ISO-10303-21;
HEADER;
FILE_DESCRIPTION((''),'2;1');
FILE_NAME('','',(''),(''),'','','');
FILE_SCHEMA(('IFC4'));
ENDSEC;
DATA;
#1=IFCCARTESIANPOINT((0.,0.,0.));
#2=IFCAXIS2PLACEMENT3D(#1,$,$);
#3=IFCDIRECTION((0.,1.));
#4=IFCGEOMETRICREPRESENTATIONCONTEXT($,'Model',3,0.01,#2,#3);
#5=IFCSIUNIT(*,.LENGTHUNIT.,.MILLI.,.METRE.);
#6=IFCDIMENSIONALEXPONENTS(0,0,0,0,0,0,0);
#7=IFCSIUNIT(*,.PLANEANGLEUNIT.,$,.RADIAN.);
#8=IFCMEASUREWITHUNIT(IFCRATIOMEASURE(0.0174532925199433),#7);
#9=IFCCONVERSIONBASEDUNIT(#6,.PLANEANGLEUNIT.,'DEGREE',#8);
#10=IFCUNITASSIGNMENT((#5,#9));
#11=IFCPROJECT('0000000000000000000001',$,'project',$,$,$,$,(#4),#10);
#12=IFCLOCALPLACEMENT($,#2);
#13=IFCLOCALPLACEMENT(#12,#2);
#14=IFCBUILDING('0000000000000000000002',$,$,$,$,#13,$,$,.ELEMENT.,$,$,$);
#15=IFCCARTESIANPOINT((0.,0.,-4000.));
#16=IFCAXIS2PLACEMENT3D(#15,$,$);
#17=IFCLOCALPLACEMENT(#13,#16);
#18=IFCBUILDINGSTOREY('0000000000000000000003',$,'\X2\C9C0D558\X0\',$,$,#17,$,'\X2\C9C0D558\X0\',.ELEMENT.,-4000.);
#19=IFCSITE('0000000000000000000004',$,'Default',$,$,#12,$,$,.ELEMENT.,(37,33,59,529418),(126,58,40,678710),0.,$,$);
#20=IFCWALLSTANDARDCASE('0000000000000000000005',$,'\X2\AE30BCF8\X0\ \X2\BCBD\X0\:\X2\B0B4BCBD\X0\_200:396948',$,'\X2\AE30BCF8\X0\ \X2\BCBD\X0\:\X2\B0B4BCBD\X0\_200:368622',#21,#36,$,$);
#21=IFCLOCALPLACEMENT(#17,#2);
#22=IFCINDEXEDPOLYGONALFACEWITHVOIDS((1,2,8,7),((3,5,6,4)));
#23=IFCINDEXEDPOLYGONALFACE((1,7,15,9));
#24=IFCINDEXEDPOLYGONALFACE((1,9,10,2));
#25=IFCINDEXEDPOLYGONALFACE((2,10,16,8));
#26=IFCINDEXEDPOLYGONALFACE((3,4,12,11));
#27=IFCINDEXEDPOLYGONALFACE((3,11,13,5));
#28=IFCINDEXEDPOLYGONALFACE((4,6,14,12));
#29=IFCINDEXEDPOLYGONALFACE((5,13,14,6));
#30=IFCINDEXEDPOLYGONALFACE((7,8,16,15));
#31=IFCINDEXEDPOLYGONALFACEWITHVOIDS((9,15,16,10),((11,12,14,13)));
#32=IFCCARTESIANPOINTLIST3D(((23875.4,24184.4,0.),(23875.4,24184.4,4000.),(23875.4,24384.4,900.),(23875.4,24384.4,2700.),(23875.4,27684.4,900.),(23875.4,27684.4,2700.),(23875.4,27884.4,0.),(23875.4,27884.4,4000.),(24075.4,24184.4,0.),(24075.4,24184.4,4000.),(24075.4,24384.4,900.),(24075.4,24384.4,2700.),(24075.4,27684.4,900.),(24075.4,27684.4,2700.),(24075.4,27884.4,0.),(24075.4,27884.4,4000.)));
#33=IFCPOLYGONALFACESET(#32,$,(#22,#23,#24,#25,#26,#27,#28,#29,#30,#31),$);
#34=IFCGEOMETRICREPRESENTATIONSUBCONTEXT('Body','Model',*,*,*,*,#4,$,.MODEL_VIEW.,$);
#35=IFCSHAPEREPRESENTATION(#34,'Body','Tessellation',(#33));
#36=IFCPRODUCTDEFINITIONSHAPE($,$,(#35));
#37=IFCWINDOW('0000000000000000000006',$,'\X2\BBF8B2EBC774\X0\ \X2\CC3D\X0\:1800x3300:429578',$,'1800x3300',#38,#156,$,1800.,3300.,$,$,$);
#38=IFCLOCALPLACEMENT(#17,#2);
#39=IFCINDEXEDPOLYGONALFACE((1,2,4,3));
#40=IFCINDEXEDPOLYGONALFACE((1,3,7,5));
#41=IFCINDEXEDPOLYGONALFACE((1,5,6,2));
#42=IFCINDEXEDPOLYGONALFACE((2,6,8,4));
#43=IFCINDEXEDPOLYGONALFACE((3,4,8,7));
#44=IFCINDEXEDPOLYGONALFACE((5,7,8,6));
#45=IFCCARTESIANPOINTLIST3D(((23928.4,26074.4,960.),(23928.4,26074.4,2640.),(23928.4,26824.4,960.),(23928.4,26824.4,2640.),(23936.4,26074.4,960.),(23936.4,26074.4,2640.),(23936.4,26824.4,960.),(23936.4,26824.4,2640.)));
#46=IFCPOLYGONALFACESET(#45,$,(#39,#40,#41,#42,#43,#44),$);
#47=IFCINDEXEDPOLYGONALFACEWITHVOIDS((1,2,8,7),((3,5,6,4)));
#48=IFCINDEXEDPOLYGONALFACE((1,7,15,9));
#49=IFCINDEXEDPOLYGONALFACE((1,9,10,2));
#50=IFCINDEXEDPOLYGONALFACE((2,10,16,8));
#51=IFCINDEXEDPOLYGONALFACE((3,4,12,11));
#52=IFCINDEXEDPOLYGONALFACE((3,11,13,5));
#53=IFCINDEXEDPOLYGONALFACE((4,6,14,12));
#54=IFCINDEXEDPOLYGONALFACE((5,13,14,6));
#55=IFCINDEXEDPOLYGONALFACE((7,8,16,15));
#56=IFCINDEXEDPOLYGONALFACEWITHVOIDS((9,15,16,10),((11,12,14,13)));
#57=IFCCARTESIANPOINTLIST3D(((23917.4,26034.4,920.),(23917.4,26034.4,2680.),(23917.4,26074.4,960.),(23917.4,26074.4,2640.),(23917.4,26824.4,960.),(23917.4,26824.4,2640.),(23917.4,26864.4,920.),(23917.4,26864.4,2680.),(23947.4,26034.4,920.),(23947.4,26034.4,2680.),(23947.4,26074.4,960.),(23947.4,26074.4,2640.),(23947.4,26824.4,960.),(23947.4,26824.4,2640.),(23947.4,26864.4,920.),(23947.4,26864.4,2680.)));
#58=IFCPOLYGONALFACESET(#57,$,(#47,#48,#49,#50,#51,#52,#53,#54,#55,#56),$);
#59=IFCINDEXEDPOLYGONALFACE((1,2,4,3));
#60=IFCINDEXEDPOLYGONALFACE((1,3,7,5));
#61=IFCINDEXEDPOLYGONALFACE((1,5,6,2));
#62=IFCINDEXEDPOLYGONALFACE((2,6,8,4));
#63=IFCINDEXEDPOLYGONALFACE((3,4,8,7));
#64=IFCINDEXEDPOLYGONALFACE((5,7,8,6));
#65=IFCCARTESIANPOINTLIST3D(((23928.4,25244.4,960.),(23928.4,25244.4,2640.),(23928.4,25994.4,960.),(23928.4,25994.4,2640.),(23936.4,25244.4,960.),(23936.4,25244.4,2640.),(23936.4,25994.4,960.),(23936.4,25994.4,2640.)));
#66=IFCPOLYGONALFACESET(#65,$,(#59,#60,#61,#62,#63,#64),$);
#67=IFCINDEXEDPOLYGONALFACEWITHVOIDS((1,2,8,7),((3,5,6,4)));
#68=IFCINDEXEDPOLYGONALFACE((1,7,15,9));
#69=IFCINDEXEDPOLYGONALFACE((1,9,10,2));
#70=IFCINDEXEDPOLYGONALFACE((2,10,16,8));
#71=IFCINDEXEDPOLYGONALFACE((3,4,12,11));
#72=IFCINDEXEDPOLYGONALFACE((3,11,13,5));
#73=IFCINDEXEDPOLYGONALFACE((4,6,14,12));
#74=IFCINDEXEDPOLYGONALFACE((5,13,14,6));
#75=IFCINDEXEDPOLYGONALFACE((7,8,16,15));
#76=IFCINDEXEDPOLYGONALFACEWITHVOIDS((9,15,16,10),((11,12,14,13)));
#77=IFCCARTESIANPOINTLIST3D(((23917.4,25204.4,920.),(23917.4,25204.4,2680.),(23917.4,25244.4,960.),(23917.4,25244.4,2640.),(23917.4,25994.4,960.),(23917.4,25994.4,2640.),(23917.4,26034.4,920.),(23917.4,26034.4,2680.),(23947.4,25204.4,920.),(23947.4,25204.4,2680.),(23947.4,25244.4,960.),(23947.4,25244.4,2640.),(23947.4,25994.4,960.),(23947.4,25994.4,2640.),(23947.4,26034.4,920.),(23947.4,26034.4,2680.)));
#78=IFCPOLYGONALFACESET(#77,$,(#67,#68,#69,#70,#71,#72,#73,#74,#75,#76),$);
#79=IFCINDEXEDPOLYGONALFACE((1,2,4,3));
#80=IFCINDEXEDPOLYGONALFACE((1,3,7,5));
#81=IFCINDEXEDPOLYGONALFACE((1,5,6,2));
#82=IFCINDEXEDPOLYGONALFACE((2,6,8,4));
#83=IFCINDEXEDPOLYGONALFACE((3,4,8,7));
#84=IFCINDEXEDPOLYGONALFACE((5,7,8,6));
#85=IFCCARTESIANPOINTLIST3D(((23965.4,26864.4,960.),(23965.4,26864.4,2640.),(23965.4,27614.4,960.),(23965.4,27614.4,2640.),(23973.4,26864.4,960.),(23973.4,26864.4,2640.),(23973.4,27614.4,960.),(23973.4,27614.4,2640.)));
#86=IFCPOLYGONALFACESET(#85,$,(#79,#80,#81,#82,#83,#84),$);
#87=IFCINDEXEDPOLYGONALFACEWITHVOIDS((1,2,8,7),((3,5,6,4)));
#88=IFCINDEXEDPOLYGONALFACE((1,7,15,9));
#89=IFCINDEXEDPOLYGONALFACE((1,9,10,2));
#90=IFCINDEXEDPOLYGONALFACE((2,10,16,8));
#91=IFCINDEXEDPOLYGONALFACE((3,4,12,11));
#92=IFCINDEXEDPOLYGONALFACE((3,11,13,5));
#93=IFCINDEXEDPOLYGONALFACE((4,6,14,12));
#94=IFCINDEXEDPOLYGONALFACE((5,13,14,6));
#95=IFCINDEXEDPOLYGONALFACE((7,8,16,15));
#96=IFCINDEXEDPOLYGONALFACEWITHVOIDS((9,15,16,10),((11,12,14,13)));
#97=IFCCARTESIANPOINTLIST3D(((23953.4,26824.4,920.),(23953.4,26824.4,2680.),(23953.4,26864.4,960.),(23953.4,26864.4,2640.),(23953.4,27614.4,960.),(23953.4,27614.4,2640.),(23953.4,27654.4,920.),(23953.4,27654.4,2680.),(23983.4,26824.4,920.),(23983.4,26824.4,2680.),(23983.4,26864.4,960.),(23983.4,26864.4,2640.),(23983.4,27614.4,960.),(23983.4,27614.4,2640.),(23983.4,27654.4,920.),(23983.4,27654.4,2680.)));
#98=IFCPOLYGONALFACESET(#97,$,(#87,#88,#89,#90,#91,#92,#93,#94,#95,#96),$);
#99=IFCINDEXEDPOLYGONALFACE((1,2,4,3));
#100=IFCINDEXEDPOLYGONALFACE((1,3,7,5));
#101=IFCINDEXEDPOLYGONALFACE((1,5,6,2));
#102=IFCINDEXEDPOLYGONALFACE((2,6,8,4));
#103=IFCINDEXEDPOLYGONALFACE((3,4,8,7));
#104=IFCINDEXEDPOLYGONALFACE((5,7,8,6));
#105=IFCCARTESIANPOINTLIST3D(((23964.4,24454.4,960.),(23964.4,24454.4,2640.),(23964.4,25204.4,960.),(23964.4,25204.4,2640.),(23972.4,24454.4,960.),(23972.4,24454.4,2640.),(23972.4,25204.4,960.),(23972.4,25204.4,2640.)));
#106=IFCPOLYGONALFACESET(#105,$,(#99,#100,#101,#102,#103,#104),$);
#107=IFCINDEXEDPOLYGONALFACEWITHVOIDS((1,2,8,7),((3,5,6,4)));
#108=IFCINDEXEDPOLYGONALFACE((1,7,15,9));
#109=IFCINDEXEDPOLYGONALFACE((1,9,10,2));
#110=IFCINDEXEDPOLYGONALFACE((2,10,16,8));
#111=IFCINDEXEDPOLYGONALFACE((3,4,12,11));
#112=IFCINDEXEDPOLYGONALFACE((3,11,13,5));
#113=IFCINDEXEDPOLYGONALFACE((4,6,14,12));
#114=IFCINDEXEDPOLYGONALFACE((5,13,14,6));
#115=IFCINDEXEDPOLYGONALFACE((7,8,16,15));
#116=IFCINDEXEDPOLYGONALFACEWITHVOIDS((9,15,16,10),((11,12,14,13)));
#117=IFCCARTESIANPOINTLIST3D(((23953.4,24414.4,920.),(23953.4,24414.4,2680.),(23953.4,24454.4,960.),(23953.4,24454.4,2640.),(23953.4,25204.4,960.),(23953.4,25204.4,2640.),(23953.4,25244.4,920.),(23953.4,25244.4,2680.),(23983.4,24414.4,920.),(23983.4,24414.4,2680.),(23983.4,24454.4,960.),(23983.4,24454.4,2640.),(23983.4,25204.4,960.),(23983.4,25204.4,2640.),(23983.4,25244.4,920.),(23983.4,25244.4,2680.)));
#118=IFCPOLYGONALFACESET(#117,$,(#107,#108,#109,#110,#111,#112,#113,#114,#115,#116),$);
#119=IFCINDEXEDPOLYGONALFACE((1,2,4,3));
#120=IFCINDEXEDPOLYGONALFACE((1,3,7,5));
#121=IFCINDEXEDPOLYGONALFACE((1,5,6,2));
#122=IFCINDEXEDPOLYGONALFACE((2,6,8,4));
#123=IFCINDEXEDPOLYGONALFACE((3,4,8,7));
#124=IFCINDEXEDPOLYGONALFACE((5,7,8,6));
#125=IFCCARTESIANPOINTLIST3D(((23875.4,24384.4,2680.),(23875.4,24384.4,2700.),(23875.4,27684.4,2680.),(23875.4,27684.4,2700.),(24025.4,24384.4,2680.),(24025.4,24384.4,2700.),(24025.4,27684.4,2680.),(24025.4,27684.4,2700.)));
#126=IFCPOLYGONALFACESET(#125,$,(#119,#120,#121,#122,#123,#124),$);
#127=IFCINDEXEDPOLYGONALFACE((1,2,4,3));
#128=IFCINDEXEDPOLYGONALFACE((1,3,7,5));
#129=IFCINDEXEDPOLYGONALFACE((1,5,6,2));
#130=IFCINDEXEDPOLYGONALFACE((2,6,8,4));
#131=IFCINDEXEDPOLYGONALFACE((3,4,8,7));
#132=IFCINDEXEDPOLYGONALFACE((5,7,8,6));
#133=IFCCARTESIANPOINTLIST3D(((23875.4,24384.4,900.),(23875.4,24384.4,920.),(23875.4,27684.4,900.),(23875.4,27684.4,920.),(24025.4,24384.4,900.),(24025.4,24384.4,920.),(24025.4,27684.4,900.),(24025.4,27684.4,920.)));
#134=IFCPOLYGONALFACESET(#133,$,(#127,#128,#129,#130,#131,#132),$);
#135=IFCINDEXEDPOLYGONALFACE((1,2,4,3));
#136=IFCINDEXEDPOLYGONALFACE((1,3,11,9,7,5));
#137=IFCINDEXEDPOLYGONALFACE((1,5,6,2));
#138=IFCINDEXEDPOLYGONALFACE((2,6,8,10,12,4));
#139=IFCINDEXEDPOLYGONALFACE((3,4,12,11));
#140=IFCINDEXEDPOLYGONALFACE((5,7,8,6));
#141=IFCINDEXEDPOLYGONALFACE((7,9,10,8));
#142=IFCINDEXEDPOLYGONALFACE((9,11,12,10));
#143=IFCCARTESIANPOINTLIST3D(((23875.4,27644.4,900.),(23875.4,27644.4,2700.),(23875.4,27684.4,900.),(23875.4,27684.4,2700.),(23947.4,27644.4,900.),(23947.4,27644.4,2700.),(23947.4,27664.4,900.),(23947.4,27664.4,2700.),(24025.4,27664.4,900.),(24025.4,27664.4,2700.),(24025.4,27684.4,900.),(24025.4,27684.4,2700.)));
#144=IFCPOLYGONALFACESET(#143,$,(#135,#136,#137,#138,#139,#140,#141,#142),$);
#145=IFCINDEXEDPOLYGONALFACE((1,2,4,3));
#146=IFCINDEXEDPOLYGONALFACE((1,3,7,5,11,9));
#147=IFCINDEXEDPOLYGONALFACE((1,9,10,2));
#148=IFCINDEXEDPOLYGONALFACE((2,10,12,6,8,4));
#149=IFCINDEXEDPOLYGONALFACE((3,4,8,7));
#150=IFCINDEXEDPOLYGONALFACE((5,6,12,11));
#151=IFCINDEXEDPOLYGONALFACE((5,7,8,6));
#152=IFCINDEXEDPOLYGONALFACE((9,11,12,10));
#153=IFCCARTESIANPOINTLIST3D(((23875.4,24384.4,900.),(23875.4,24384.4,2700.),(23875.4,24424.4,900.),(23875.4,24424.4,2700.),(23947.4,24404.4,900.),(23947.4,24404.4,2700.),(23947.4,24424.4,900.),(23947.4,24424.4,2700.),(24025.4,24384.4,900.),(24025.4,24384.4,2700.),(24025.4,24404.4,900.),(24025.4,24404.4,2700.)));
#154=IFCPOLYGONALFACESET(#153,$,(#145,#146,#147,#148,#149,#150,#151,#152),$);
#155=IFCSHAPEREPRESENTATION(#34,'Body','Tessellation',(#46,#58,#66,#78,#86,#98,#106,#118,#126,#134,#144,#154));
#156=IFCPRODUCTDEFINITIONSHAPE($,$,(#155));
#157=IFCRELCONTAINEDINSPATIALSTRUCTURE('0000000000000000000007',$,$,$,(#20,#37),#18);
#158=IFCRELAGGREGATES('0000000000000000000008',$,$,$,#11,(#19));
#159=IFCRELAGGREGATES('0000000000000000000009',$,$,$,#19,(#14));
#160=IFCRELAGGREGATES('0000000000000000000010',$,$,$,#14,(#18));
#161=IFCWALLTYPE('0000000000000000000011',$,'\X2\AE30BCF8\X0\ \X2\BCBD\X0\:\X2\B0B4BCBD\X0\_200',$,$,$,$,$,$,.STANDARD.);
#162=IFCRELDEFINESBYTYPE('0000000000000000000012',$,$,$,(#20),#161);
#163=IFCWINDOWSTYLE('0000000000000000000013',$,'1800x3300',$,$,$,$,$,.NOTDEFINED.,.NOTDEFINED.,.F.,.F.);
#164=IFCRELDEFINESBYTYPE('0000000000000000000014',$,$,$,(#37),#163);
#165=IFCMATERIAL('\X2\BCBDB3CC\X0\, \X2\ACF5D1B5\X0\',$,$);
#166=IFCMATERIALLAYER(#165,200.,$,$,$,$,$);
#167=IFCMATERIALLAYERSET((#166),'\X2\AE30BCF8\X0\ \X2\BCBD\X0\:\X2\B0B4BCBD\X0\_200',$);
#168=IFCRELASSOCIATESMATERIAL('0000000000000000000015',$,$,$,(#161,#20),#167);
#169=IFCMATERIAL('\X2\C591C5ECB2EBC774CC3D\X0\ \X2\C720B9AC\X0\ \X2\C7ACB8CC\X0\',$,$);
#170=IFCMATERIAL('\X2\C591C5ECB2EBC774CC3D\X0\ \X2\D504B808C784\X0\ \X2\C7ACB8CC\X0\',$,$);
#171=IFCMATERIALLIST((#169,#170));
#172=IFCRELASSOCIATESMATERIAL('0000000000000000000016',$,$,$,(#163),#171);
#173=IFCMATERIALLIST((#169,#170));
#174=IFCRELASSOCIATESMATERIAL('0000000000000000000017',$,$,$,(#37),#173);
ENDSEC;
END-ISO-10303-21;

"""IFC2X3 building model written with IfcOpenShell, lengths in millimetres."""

from ifc_helpers import new_model, entity, si_unit, converted_unit, direction, frame, frame_2d, origin, origin_2d_with_axis, place, context, subcontext, project, spatial, polyline, rectangle, outline, extrude, source, transform, mapped, material, material_list, layer, layer_set, layer_usage, type_object, type_shapes, element, fill, save


model = new_model("IFC2X3")

# Units and contexts
model_context = context("Model", 3, precision=0.01, world=origin(), true_north=direction((0.0, 1.0)))
body_context = subcontext(model_context, "Body", "Model", "MODEL_VIEW")
ifc_project = project(units=[si_unit("LENGTHUNIT", "METRE", prefix="MILLI"), converted_unit("PLANEANGLEUNIT", "DEGREE", entity("IfcRatioMeasure", 0.0174532925199433), si_unit("PLANEANGLEUNIT", "RADIAN"), dimensions=[0, 0, 0, 0, 0, 0, 0])], contexts=[model_context])

# Site, building, storey
site_placement = place(None, origin())
site = spatial("IfcSite", under=ifc_project, at=site_placement, Name="Default", CompositionType="ELEMENT", RefLatitude=(37, 33, 59, 529418), RefLongitude=(126, 58, 40, 678710), RefElevation=0.0)
building_placement = place(site_placement, origin())
building = spatial("IfcBuilding", under=site, at=building_placement, CompositionType="ELEMENT")
storey_placement = place(building_placement, frame((0.0, 0.0, -4000.0)))
storey = spatial("IfcBuildingStorey", under=building, at=storey_placement, Name="지하", LongName="지하", CompositionType="ELEMENT", Elevation=-4000.0)

# Shared definitions
ifc_material_1 = material(Name="양여닫이창 유리 재료")
ifc_material_2 = material(Name="양여닫이창 프레임 재료")

# Shared definitions
ifc_material_3 = material(Name="벽돌, 공통")
ifc_layer_1 = layer(ifc_material_3, 200.0)
ifc_layer_set_1 = layer_set([ifc_layer_1], Name="기본 벽:내벽_200")
wall_type_1 = type_object("IfcWallType", Name="기본 벽:내벽_200", PredefinedType="STANDARD", material=ifc_layer_set_1)

# Wall, opening, window
ifc_layer_usage_1 = layer_usage(ifc_layer_set_1, "AXIS2", "NEGATIVE", 100.0)
wall_1_placement = place(storey_placement, frame((23975.4, 27884.4, 0.0), z_axis=(0.0, 0.0, 1.0), x_axis=(0.0, -1.0, 0.0)))
wall_1 = element("IfcWallStandardCase", 1, at=wall_1_placement, inside=storey, type_object=wall_type_1, material=ifc_layer_usage_1, Name="기본 벽:내벽_200:396948", ObjectType="기본 벽:내벽_200:368622", context=body_context, shape_type="SweptSolid", body=[
    extrude(rectangle(XDim=3700.0, YDim=200.0, at=frame_2d((1850.0, 0.0), x_axis=(-1.0, 0.0))), origin(), (0.0, 0.0, 1.0), 4000.0),
])
opening_1_placement = place(wall_1_placement, frame((3500.0, 100.0, 900.0)))
opening_1 = element("IfcOpeningElement", 2, at=opening_1_placement, cuts=wall_1, ObjectType="Opening", context=body_context, shape_type="SweptSolid", body=[
    extrude(rectangle(XDim=1800.0, YDim=3300.0, at=frame_2d((900.0, 1650.0), x_axis=(1.0, 0.0))), frame((0.0, 0.0, 0.0), z_axis=(0.0, -1.0, 0.0), x_axis=(0.0, 0.0, 1.0)), (0.0, 0.0, 1.0), 200.0),
])
ifc_material_list_1 = material_list([ifc_material_1, ifc_material_2])
ifc_material_list_2 = material_list([ifc_material_1, ifc_material_2])
window_style_1 = type_object("IfcWindowStyle", Name="1800x3300", ConstructionType="NOTDEFINED", OperationType="NOTDEFINED", ParameterTakesPrecedence=False, Sizeable=False, material=ifc_material_list_2)
shared_shape_1 = source(origin(), body_context, "Body", "SweptSolid", [
    extrude(rectangle(XDim=8.0, YDim=750.0, at=frame_2d((0.0, 0.0), x_axis=(1.0, 0.0))), frame((2065.0, 143.0, 60.0), z_axis=(0.0, 0.0, 1.0), x_axis=(0.0, 1.0, 0.0)), (0.0, 0.0, 1.0), 1680.0),
    extrude(outline(polyline([(-880.0, -415.0), (880.0, -415.0), (880.0, 415.0), (-880.0, 415.0), (-880.0, -415.0)]), holes=[polyline([(840.0, -375.0), (-840.0, -375.0), (-840.0, 375.0), (840.0, 375.0), (840.0, -375.0)])]), frame((2065.0, 128.0, 900.0), z_axis=(0.0, 1.0, 0.0), x_axis=(0.0, 0.0, -1.0)), (0.0, 0.0, 1.0), 30.0),
    extrude(rectangle(XDim=8.0, YDim=750.0, at=frame_2d((0.0, 0.0), x_axis=(1.0, 0.0))), frame((1235.0, 143.0, 60.0), z_axis=(0.0, 0.0, 1.0), x_axis=(0.0, 1.0, 0.0)), (0.0, 0.0, 1.0), 1680.0),
    extrude(outline(polyline([(-880.0, -415.0), (880.0, -415.0), (880.0, 415.0), (-880.0, 415.0), (-880.0, -415.0)]), holes=[polyline([(840.0, -375.0), (-840.0, -375.0), (-840.0, 375.0), (840.0, 375.0), (840.0, -375.0)])]), frame((1235.0, 128.0, 900.0), z_axis=(0.0, 1.0, 0.0), x_axis=(0.0, 0.0, -1.0)), (0.0, 0.0, 1.0), 30.0),
    extrude(rectangle(XDim=8.0, YDim=750.0, at=frame_2d((0.0, 0.0), x_axis=(1.0, 0.0))), frame((2855.0, 106.0, 60.0), z_axis=(0.0, 0.0, 1.0), x_axis=(0.0, 1.0, 0.0)), (0.0, 0.0, 1.0), 1680.0),
    extrude(outline(polyline([(-880.0, -415.0), (880.0, -415.0), (880.0, 415.0), (-880.0, 415.0), (-880.0, -415.0)]), holes=[polyline([(840.0, -375.0), (-840.0, -375.0), (-840.0, 375.0), (840.0, 375.0), (840.0, -375.0)])]), frame((2855.0, 92.0, 900.0), z_axis=(0.0, 1.0, 0.0), x_axis=(0.0, 0.0, -1.0)), (0.0, 0.0, 1.0), 30.0),
    extrude(rectangle(XDim=8.0, YDim=750.0, at=origin_2d_with_axis()), frame((445.0, 107.0, 60.0), z_axis=(0.0, 0.0, 1.0), x_axis=(0.0, 1.0, 0.0)), (0.0, 0.0, 1.0), 1680.0),
    extrude(outline(polyline([(-880.0, -415.0), (880.0, -415.0), (880.0, 415.0), (-880.0, 415.0), (-880.0, -415.0)]), holes=[polyline([(840.0, -375.0), (-840.0, -375.0), (-840.0, 375.0), (840.0, 375.0), (840.0, -375.0)])]), frame((445.0, 92.0, 900.0), z_axis=(0.0, 1.0, 0.0), x_axis=(0.0, 0.0, -1.0)), (0.0, 0.0, 1.0), 30.0),
    extrude(rectangle(XDim=3300.0, YDim=150.0, at=origin_2d_with_axis()), frame((1650.0, 125.0, 1780.0), z_axis=(0.0, 0.0, 1.0), x_axis=(-1.0, 0.0, 0.0)), (0.0, 0.0, 1.0), 20.0),
    extrude(rectangle(XDim=3300.0, YDim=150.0, at=origin_2d_with_axis()), frame((1650.0, 125.0, 0.0), z_axis=(0.0, 0.0, 1.0), x_axis=(-1.0, 0.0, 0.0)), (0.0, 0.0, 1.0), 20.0),
    extrude(outline(polyline([(-74.0, -20.0), (-2.0, -20.0), (-2.0, 0.0), (76.0, 0.0), (76.0, 20.0), (-74.0, 20.0), (-74.0, -20.0)])), frame((3280.0, 126.0, 0.0), z_axis=(0.0, 0.0, 1.0), x_axis=(0.0, -1.0, 0.0)), (0.0, 0.0, 1.0), 1800.0),
    extrude(outline(polyline([(-20.0, -74.0), (20.0, -74.0), (20.0, 76.0), (0.0, 76.0), (0.0, -2.0), (-20.0, -2.0), (-20.0, -74.0)])), frame((20.0, 126.0, 0.0), z_axis=(0.0, 0.0, 1.0), x_axis=(-1.0, 0.0, 0.0)), (0.0, 0.0, 1.0), 1800.0),
])
type_shapes(window_style_1, [shared_shape_1])
window_1_placement = place(opening_1_placement, frame((0.0, 0.0, 0.0), z_axis=(0.0, 0.0, 1.0), x_axis=(-1.0, 0.0, 0.0)))
window_1 = element("IfcWindow", 3, at=window_1_placement, inside=storey, type_object=window_style_1, material=ifc_material_list_1, Name="미닫이 창:1800x3300:429578", ObjectType="1800x3300", OverallHeight=1800.0, OverallWidth=3300.0, context=body_context, shape_type="MappedRepresentation", body=[
    mapped(shared_shape_1, transform((0.0, 0.0, 0.0), scale=1.0)),
])
fill(opening_1, window_1)

save(model, "model.ifc")
